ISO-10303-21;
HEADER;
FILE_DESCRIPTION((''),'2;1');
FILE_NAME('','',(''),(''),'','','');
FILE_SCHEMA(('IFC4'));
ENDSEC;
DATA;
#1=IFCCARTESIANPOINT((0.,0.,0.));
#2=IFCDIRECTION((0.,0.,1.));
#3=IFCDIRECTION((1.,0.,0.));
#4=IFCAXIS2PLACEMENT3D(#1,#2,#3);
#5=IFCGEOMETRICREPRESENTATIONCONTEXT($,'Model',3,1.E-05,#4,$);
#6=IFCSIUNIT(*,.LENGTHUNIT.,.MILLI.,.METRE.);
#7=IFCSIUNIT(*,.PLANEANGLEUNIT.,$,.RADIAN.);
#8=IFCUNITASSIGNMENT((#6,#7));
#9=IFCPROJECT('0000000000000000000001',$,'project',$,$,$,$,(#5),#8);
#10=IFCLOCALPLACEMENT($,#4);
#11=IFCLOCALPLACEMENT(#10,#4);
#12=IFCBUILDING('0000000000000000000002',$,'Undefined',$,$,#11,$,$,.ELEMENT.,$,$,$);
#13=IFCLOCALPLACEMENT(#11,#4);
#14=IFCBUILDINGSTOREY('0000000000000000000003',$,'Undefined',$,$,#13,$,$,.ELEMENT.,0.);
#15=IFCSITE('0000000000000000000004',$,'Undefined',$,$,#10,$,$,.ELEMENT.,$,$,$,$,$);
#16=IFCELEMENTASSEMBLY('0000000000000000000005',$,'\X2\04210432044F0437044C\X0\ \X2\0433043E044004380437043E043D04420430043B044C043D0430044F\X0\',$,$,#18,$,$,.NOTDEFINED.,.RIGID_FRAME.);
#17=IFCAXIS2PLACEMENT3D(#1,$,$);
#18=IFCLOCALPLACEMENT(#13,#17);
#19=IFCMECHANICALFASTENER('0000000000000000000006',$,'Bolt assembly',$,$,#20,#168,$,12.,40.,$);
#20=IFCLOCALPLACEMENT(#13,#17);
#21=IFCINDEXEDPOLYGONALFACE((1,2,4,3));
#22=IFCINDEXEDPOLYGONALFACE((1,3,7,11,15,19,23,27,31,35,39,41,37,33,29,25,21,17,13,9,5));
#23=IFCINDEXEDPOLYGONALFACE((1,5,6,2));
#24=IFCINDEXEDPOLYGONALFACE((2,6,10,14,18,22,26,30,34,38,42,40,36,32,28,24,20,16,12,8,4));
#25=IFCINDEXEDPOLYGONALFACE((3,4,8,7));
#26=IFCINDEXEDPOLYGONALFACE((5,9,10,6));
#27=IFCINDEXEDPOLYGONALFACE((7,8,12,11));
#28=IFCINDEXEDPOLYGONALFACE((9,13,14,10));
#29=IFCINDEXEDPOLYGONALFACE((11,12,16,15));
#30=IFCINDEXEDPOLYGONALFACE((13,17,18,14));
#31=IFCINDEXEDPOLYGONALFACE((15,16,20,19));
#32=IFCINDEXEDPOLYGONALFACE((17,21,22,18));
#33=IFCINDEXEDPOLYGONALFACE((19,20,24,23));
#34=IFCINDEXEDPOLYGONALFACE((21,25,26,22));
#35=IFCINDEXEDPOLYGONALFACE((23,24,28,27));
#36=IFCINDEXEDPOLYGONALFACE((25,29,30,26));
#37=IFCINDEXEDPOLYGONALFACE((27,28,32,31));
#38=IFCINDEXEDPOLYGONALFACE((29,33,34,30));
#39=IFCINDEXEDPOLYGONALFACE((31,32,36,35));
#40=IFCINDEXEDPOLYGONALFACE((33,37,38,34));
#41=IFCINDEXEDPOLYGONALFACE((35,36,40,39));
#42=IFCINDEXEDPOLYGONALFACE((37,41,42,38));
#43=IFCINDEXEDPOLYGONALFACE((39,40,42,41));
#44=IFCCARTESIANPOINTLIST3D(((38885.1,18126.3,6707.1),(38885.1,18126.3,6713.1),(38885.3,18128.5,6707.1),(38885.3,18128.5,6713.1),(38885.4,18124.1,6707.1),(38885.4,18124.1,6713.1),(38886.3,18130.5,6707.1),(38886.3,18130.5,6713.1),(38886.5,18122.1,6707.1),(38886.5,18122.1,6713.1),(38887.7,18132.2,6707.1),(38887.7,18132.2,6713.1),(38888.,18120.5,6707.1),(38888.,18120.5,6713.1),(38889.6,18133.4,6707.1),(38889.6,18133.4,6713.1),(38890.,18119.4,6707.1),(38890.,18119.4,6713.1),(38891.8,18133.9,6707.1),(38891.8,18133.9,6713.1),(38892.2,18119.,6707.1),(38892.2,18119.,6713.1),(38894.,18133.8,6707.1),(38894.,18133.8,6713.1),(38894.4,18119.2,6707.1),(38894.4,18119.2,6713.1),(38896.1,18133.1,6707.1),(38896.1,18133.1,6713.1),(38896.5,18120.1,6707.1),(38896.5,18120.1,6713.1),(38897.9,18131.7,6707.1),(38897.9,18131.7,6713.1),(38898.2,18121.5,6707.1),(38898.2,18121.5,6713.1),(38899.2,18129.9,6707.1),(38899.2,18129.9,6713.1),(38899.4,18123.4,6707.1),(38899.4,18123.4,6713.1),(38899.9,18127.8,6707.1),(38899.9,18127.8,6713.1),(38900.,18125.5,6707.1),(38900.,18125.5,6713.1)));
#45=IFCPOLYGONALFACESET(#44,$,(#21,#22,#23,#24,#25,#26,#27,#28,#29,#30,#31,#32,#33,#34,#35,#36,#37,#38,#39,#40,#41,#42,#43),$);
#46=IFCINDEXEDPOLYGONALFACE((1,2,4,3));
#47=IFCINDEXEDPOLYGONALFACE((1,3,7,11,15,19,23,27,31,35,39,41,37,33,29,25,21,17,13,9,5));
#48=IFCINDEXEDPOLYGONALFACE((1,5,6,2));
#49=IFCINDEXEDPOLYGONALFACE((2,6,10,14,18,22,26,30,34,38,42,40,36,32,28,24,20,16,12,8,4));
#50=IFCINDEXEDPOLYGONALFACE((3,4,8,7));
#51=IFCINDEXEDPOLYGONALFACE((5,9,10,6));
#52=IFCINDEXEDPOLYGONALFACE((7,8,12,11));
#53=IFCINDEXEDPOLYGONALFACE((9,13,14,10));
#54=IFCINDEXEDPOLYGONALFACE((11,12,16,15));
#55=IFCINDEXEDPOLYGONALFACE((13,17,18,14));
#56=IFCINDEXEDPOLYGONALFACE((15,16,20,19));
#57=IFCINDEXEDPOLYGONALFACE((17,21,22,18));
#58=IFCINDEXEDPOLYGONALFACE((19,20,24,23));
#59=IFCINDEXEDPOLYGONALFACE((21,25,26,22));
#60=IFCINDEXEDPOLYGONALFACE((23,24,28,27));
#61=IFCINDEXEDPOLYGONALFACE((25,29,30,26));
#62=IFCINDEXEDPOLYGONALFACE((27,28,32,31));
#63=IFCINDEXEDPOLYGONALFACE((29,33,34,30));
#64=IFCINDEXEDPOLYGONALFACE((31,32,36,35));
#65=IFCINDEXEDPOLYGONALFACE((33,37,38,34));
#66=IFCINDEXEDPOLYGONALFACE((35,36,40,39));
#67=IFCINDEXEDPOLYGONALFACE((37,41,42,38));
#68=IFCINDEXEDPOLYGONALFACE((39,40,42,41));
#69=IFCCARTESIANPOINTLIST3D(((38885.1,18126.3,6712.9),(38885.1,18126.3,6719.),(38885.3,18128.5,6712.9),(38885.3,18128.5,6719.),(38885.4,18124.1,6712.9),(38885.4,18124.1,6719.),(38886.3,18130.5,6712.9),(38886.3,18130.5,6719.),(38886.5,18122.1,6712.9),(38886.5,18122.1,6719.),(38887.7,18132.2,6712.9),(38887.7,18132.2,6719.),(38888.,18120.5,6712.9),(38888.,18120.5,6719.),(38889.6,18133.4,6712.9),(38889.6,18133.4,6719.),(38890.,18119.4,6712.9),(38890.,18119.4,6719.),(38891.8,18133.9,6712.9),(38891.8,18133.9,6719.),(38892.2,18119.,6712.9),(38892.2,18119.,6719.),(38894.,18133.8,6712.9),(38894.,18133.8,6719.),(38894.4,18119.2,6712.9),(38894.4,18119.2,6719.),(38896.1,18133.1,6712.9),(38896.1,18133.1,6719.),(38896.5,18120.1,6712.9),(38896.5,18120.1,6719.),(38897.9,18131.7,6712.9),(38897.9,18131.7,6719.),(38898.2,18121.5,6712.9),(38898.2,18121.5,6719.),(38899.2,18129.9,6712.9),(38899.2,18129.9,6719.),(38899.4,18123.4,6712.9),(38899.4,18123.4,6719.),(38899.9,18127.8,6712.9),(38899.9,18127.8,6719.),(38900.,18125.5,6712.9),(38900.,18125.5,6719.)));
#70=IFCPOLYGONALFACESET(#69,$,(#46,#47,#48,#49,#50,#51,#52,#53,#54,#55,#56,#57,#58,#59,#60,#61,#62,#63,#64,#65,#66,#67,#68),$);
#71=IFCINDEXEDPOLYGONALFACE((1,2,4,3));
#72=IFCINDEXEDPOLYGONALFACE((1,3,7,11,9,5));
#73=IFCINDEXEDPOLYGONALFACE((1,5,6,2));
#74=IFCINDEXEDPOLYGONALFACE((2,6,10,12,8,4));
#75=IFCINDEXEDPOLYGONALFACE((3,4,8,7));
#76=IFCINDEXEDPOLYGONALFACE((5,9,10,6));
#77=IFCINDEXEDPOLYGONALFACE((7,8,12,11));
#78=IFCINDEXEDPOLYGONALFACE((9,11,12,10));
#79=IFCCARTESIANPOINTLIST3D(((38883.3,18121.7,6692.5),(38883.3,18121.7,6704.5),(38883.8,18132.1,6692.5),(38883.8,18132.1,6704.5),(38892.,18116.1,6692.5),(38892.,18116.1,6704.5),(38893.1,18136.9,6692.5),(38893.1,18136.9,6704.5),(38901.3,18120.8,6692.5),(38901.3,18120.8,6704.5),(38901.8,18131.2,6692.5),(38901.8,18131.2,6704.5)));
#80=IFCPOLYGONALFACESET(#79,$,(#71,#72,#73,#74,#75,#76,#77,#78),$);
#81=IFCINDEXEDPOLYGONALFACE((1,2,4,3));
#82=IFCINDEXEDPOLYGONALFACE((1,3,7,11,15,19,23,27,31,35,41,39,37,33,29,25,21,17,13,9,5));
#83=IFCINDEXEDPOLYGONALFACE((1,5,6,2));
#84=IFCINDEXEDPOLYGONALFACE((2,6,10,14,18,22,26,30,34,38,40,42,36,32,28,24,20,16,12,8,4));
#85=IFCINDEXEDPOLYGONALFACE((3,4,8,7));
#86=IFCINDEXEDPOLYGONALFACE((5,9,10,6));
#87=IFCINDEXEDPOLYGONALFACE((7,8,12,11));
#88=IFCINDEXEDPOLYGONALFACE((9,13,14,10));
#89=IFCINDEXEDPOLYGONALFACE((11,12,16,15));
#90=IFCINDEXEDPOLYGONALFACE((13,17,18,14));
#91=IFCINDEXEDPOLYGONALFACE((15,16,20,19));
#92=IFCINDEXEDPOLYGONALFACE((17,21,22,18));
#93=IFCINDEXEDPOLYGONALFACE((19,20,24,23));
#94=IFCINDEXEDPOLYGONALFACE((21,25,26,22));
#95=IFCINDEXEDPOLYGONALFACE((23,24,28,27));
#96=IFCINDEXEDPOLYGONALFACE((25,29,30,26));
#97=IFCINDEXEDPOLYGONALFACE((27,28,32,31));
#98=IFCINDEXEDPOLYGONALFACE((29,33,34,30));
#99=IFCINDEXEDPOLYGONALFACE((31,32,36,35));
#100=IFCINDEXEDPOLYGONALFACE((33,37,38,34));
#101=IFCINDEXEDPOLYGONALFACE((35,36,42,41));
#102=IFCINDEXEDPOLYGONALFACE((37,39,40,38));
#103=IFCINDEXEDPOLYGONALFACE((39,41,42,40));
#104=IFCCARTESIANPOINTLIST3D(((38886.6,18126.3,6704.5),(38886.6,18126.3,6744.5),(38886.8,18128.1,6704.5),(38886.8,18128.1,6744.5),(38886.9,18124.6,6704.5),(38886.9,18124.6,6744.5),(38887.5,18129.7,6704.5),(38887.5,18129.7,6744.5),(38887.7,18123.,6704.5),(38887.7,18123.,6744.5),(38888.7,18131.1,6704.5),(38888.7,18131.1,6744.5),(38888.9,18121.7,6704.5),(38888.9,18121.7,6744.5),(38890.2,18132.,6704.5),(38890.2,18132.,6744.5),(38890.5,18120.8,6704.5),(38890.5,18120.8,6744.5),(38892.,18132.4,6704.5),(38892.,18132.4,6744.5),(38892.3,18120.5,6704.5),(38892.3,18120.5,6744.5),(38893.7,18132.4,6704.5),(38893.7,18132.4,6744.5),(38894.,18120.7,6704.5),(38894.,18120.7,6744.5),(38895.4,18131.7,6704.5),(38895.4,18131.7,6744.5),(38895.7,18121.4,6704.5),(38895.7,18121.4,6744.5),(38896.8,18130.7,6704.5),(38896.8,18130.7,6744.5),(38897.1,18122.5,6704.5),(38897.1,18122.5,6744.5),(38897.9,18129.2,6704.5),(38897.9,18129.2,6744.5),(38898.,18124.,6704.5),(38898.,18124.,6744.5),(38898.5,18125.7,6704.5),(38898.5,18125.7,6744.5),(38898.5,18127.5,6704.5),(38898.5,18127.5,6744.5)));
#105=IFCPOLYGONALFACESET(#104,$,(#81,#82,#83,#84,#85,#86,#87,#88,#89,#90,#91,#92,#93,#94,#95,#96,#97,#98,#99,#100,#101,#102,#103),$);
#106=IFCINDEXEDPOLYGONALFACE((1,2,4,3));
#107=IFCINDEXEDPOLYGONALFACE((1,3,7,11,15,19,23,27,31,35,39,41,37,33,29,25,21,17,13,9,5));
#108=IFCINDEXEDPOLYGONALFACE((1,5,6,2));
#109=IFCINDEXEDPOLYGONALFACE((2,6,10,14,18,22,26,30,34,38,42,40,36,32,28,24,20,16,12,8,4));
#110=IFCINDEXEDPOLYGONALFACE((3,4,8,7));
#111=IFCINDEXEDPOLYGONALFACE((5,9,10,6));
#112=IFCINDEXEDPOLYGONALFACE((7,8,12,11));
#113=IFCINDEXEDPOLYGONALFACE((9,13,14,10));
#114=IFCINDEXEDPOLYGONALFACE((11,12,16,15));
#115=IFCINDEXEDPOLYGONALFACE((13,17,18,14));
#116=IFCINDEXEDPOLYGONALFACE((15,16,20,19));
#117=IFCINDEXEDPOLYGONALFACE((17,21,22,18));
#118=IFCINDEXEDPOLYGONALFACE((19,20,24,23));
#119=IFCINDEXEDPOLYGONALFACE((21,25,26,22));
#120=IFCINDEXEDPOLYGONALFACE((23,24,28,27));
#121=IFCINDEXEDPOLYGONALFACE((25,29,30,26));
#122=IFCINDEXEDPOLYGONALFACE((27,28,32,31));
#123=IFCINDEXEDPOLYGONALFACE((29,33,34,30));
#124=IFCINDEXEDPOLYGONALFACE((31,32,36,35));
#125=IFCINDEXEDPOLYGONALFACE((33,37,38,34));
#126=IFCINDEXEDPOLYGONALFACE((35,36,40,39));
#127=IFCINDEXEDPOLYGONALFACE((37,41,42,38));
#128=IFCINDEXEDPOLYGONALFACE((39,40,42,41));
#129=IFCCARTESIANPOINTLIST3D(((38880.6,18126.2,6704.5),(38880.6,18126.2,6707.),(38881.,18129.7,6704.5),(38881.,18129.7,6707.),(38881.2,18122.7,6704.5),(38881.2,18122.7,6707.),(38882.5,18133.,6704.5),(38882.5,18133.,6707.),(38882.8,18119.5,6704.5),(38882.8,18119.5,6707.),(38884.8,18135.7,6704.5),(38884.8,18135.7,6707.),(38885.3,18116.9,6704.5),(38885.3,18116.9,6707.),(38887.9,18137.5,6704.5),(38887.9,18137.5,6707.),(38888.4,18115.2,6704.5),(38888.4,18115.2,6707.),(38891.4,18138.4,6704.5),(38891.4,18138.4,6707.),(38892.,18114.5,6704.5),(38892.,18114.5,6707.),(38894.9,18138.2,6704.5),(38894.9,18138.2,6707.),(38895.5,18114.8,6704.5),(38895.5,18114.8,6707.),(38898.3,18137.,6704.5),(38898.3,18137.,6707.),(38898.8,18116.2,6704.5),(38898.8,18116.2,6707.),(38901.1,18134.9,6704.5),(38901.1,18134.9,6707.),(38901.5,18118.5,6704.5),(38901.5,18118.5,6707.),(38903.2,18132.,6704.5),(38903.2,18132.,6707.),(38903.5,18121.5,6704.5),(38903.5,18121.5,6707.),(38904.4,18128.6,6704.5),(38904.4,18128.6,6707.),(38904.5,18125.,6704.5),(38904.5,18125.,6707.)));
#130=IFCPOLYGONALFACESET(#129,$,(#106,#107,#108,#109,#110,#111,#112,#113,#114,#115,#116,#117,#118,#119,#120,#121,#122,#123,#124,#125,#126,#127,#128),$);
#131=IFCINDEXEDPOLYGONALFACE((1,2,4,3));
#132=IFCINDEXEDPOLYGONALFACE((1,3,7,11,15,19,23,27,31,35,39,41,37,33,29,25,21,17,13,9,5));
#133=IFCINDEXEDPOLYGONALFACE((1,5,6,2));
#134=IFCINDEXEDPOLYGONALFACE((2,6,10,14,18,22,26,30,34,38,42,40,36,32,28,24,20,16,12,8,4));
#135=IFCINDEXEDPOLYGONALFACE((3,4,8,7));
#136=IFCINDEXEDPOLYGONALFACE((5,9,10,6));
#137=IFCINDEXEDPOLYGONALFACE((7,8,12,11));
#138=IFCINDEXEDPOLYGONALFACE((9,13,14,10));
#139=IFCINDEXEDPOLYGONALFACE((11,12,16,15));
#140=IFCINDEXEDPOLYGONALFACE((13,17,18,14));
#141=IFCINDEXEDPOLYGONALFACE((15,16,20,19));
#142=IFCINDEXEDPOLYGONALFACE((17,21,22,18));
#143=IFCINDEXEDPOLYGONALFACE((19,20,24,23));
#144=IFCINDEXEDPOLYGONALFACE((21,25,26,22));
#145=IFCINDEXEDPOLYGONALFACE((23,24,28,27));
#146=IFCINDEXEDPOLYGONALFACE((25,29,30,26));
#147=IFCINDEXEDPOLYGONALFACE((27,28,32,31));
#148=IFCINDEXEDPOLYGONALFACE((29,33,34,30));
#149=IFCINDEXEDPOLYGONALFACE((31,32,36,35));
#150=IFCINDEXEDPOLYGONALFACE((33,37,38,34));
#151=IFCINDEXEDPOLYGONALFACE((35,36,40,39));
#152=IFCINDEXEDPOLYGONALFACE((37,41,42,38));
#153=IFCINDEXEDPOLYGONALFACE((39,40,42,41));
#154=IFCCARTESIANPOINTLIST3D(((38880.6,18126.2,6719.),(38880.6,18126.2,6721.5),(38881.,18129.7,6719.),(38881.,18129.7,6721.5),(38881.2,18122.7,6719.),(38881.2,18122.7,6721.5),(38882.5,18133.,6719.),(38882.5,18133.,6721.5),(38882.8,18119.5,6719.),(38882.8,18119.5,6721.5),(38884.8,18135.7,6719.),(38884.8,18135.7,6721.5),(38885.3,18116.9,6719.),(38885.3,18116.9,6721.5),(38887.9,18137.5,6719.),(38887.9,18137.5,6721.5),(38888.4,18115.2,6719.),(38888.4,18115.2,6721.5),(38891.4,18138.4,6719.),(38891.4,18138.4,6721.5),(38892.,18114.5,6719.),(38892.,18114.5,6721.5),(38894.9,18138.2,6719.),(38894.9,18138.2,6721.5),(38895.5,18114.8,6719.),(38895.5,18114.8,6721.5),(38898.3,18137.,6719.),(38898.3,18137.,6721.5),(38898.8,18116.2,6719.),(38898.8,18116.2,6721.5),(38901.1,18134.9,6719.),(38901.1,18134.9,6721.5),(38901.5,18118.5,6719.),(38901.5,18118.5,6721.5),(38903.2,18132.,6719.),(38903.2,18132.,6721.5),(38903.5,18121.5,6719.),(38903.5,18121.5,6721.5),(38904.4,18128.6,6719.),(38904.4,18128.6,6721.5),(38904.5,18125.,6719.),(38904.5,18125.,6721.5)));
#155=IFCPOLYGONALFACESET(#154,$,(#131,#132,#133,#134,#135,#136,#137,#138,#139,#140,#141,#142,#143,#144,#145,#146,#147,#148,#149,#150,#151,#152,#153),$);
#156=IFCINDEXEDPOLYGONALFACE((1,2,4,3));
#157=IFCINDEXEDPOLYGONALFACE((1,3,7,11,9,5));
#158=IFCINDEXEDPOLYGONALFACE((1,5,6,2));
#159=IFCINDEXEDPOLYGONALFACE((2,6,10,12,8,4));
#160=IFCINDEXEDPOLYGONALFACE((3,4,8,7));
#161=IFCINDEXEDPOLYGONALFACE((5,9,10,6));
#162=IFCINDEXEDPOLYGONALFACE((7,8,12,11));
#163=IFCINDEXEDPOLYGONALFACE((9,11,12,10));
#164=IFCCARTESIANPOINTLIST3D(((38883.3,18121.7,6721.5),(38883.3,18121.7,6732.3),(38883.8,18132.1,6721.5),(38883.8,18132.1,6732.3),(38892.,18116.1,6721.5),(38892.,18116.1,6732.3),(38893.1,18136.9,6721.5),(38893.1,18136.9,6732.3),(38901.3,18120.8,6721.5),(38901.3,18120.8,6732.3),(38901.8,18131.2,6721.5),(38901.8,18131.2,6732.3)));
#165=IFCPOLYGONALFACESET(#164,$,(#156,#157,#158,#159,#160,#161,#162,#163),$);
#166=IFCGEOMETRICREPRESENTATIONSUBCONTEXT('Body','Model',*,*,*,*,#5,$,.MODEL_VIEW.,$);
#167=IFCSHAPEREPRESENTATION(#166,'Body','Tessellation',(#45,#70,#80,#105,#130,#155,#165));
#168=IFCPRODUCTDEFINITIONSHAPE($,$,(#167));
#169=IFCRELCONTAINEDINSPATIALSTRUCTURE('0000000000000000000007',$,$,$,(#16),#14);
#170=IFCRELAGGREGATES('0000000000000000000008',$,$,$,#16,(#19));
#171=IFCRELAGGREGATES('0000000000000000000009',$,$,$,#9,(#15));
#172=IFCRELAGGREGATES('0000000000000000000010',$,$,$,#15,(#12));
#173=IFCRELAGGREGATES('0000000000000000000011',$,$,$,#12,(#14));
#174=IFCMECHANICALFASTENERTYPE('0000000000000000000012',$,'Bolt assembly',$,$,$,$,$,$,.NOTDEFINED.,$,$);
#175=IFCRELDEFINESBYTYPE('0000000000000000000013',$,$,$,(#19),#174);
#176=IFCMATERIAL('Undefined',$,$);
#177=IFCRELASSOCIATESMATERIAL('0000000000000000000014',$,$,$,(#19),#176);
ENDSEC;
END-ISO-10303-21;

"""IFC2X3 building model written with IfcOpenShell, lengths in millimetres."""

from ifc_helpers import new_model, si_unit, frame, origin_with_axes, origin_2d_with_axis, place, context, subcontext, project, spatial, polyline, circle, outline, extrude, source, transform, mapped, material, type_object, element, aggregate, save


model = new_model("IFC2X3")

# Units and contexts
model_context = context("Model", 3, precision=1e-05, world=origin_with_axes())
body_context = subcontext(model_context, "Body", "Model", "MODEL_VIEW")
ifc_project = project(units=[si_unit("LENGTHUNIT", "METRE", prefix="MILLI"), si_unit("PLANEANGLEUNIT", "RADIAN")], contexts=[model_context])

# Site, building, storey
site_placement = place(None, origin_with_axes())
site = spatial("IfcSite", under=ifc_project, at=site_placement, Name="Undefined", CompositionType="ELEMENT")
building_placement = place(site_placement, origin_with_axes())
building = spatial("IfcBuilding", under=site, at=building_placement, Name="Undefined", CompositionType="ELEMENT")
storey_placement = place(building_placement, origin_with_axes())
storey = spatial("IfcBuildingStorey", under=building, at=storey_placement, Name="Undefined", CompositionType="ELEMENT", Elevation=0.0)

# Element assembly
assembly_1_placement = place(storey_placement, origin_with_axes())
assembly_1 = element("IfcElementAssembly", 1, at=assembly_1_placement, inside=storey, Name="Связь горизонтальная", AssemblyPlace="NOTDEFINED", PredefinedType="RIGID_FRAME")

# Mechanical fastener
ifc_material_1 = material(Name="Undefined")
mechanical_fastener_type = type_object("IfcMechanicalFastenerType", Name="Bolt assembly")
shared_shape_1 = source(origin_with_axes(), body_context, "Body", "SweptSolid", [
    extrude(circle(Radius=7.5, at=origin_2d_with_axis()), frame((0.0, 0.1, 0.0), z_axis=(0.0, 1.0, 0.0), x_axis=(1.0, 0.0, 0.0)), (0.0, 0.0, 1.0), 6.0),
    extrude(circle(Radius=7.5, at=origin_2d_with_axis()), frame((0.0, 5.9, 0.0), z_axis=(0.0, 1.0, 0.0), x_axis=(1.0, 0.0, 0.0)), (0.0, 0.0, 1.0), 6.1),
    extrude(outline(polyline([(10.4, 0.0), (5.2, 9.0), (-5.2, 9.0), (-10.4, 0.0), (-5.2, -9.0), (5.2, -9.0), (10.4, 0.0)])), frame((0.0, -14.5, 0.0), z_axis=(0.0, 1.0, 0.0), x_axis=(1.0, 0.0, 0.0)), (0.0, 0.0, 1.0), 12.0),
    extrude(circle(Radius=6.0, at=origin_2d_with_axis()), frame((0.0, -2.5, 0.0), z_axis=(0.0, 1.0, 0.0), x_axis=(1.0, 0.0, 0.0)), (0.0, 0.0, 1.0), 40.0),
    extrude(circle(Radius=12.0, at=origin_2d_with_axis()), frame((0.0, -2.5, 0.0), z_axis=(0.0, 1.0, 0.0), x_axis=(1.0, 0.0, 0.0)), (0.0, 0.0, 1.0), 2.5),
    extrude(circle(Radius=12.0, at=origin_2d_with_axis()), frame((0.0, 12.0, 0.0), z_axis=(0.0, 1.0, 0.0), x_axis=(1.0, 0.0, 0.0)), (0.0, 0.0, 1.0), 2.5),
    extrude(outline(polyline([(10.4, 0.0), (5.2, 9.0), (-5.2, 9.0), (-10.4, 0.0), (-5.2, -9.0), (5.2, -9.0), (10.4, 0.0)])), frame((0.0, 14.5, 0.0), z_axis=(0.0, 1.0, 0.0), x_axis=(1.0, 0.0, 0.0)), (0.0, 0.0, 1.0), 10.8),
])
mechanical_fastener_1_placement = place(assembly_1_placement, frame((38892.6, 18126.5, 6707.0), z_axis=(0.542525, 0.840039, 0.0), x_axis=(-0.840039, 0.542525, 0.0)))
mechanical_fastener_1 = element("IfcMechanicalFastener", 2, at=mechanical_fastener_1_placement, type_object=mechanical_fastener_type, material=ifc_material_1, Name="Bolt assembly", NominalDiameter=12.0, NominalLength=40.0, context=body_context, shape_type="MappedRepresentation", body=[
    mapped(shared_shape_1, transform((0.0, 0.0, 0.0))),
])
aggregate(assembly_1, [mechanical_fastener_1])

save(model, "model.ifc")
